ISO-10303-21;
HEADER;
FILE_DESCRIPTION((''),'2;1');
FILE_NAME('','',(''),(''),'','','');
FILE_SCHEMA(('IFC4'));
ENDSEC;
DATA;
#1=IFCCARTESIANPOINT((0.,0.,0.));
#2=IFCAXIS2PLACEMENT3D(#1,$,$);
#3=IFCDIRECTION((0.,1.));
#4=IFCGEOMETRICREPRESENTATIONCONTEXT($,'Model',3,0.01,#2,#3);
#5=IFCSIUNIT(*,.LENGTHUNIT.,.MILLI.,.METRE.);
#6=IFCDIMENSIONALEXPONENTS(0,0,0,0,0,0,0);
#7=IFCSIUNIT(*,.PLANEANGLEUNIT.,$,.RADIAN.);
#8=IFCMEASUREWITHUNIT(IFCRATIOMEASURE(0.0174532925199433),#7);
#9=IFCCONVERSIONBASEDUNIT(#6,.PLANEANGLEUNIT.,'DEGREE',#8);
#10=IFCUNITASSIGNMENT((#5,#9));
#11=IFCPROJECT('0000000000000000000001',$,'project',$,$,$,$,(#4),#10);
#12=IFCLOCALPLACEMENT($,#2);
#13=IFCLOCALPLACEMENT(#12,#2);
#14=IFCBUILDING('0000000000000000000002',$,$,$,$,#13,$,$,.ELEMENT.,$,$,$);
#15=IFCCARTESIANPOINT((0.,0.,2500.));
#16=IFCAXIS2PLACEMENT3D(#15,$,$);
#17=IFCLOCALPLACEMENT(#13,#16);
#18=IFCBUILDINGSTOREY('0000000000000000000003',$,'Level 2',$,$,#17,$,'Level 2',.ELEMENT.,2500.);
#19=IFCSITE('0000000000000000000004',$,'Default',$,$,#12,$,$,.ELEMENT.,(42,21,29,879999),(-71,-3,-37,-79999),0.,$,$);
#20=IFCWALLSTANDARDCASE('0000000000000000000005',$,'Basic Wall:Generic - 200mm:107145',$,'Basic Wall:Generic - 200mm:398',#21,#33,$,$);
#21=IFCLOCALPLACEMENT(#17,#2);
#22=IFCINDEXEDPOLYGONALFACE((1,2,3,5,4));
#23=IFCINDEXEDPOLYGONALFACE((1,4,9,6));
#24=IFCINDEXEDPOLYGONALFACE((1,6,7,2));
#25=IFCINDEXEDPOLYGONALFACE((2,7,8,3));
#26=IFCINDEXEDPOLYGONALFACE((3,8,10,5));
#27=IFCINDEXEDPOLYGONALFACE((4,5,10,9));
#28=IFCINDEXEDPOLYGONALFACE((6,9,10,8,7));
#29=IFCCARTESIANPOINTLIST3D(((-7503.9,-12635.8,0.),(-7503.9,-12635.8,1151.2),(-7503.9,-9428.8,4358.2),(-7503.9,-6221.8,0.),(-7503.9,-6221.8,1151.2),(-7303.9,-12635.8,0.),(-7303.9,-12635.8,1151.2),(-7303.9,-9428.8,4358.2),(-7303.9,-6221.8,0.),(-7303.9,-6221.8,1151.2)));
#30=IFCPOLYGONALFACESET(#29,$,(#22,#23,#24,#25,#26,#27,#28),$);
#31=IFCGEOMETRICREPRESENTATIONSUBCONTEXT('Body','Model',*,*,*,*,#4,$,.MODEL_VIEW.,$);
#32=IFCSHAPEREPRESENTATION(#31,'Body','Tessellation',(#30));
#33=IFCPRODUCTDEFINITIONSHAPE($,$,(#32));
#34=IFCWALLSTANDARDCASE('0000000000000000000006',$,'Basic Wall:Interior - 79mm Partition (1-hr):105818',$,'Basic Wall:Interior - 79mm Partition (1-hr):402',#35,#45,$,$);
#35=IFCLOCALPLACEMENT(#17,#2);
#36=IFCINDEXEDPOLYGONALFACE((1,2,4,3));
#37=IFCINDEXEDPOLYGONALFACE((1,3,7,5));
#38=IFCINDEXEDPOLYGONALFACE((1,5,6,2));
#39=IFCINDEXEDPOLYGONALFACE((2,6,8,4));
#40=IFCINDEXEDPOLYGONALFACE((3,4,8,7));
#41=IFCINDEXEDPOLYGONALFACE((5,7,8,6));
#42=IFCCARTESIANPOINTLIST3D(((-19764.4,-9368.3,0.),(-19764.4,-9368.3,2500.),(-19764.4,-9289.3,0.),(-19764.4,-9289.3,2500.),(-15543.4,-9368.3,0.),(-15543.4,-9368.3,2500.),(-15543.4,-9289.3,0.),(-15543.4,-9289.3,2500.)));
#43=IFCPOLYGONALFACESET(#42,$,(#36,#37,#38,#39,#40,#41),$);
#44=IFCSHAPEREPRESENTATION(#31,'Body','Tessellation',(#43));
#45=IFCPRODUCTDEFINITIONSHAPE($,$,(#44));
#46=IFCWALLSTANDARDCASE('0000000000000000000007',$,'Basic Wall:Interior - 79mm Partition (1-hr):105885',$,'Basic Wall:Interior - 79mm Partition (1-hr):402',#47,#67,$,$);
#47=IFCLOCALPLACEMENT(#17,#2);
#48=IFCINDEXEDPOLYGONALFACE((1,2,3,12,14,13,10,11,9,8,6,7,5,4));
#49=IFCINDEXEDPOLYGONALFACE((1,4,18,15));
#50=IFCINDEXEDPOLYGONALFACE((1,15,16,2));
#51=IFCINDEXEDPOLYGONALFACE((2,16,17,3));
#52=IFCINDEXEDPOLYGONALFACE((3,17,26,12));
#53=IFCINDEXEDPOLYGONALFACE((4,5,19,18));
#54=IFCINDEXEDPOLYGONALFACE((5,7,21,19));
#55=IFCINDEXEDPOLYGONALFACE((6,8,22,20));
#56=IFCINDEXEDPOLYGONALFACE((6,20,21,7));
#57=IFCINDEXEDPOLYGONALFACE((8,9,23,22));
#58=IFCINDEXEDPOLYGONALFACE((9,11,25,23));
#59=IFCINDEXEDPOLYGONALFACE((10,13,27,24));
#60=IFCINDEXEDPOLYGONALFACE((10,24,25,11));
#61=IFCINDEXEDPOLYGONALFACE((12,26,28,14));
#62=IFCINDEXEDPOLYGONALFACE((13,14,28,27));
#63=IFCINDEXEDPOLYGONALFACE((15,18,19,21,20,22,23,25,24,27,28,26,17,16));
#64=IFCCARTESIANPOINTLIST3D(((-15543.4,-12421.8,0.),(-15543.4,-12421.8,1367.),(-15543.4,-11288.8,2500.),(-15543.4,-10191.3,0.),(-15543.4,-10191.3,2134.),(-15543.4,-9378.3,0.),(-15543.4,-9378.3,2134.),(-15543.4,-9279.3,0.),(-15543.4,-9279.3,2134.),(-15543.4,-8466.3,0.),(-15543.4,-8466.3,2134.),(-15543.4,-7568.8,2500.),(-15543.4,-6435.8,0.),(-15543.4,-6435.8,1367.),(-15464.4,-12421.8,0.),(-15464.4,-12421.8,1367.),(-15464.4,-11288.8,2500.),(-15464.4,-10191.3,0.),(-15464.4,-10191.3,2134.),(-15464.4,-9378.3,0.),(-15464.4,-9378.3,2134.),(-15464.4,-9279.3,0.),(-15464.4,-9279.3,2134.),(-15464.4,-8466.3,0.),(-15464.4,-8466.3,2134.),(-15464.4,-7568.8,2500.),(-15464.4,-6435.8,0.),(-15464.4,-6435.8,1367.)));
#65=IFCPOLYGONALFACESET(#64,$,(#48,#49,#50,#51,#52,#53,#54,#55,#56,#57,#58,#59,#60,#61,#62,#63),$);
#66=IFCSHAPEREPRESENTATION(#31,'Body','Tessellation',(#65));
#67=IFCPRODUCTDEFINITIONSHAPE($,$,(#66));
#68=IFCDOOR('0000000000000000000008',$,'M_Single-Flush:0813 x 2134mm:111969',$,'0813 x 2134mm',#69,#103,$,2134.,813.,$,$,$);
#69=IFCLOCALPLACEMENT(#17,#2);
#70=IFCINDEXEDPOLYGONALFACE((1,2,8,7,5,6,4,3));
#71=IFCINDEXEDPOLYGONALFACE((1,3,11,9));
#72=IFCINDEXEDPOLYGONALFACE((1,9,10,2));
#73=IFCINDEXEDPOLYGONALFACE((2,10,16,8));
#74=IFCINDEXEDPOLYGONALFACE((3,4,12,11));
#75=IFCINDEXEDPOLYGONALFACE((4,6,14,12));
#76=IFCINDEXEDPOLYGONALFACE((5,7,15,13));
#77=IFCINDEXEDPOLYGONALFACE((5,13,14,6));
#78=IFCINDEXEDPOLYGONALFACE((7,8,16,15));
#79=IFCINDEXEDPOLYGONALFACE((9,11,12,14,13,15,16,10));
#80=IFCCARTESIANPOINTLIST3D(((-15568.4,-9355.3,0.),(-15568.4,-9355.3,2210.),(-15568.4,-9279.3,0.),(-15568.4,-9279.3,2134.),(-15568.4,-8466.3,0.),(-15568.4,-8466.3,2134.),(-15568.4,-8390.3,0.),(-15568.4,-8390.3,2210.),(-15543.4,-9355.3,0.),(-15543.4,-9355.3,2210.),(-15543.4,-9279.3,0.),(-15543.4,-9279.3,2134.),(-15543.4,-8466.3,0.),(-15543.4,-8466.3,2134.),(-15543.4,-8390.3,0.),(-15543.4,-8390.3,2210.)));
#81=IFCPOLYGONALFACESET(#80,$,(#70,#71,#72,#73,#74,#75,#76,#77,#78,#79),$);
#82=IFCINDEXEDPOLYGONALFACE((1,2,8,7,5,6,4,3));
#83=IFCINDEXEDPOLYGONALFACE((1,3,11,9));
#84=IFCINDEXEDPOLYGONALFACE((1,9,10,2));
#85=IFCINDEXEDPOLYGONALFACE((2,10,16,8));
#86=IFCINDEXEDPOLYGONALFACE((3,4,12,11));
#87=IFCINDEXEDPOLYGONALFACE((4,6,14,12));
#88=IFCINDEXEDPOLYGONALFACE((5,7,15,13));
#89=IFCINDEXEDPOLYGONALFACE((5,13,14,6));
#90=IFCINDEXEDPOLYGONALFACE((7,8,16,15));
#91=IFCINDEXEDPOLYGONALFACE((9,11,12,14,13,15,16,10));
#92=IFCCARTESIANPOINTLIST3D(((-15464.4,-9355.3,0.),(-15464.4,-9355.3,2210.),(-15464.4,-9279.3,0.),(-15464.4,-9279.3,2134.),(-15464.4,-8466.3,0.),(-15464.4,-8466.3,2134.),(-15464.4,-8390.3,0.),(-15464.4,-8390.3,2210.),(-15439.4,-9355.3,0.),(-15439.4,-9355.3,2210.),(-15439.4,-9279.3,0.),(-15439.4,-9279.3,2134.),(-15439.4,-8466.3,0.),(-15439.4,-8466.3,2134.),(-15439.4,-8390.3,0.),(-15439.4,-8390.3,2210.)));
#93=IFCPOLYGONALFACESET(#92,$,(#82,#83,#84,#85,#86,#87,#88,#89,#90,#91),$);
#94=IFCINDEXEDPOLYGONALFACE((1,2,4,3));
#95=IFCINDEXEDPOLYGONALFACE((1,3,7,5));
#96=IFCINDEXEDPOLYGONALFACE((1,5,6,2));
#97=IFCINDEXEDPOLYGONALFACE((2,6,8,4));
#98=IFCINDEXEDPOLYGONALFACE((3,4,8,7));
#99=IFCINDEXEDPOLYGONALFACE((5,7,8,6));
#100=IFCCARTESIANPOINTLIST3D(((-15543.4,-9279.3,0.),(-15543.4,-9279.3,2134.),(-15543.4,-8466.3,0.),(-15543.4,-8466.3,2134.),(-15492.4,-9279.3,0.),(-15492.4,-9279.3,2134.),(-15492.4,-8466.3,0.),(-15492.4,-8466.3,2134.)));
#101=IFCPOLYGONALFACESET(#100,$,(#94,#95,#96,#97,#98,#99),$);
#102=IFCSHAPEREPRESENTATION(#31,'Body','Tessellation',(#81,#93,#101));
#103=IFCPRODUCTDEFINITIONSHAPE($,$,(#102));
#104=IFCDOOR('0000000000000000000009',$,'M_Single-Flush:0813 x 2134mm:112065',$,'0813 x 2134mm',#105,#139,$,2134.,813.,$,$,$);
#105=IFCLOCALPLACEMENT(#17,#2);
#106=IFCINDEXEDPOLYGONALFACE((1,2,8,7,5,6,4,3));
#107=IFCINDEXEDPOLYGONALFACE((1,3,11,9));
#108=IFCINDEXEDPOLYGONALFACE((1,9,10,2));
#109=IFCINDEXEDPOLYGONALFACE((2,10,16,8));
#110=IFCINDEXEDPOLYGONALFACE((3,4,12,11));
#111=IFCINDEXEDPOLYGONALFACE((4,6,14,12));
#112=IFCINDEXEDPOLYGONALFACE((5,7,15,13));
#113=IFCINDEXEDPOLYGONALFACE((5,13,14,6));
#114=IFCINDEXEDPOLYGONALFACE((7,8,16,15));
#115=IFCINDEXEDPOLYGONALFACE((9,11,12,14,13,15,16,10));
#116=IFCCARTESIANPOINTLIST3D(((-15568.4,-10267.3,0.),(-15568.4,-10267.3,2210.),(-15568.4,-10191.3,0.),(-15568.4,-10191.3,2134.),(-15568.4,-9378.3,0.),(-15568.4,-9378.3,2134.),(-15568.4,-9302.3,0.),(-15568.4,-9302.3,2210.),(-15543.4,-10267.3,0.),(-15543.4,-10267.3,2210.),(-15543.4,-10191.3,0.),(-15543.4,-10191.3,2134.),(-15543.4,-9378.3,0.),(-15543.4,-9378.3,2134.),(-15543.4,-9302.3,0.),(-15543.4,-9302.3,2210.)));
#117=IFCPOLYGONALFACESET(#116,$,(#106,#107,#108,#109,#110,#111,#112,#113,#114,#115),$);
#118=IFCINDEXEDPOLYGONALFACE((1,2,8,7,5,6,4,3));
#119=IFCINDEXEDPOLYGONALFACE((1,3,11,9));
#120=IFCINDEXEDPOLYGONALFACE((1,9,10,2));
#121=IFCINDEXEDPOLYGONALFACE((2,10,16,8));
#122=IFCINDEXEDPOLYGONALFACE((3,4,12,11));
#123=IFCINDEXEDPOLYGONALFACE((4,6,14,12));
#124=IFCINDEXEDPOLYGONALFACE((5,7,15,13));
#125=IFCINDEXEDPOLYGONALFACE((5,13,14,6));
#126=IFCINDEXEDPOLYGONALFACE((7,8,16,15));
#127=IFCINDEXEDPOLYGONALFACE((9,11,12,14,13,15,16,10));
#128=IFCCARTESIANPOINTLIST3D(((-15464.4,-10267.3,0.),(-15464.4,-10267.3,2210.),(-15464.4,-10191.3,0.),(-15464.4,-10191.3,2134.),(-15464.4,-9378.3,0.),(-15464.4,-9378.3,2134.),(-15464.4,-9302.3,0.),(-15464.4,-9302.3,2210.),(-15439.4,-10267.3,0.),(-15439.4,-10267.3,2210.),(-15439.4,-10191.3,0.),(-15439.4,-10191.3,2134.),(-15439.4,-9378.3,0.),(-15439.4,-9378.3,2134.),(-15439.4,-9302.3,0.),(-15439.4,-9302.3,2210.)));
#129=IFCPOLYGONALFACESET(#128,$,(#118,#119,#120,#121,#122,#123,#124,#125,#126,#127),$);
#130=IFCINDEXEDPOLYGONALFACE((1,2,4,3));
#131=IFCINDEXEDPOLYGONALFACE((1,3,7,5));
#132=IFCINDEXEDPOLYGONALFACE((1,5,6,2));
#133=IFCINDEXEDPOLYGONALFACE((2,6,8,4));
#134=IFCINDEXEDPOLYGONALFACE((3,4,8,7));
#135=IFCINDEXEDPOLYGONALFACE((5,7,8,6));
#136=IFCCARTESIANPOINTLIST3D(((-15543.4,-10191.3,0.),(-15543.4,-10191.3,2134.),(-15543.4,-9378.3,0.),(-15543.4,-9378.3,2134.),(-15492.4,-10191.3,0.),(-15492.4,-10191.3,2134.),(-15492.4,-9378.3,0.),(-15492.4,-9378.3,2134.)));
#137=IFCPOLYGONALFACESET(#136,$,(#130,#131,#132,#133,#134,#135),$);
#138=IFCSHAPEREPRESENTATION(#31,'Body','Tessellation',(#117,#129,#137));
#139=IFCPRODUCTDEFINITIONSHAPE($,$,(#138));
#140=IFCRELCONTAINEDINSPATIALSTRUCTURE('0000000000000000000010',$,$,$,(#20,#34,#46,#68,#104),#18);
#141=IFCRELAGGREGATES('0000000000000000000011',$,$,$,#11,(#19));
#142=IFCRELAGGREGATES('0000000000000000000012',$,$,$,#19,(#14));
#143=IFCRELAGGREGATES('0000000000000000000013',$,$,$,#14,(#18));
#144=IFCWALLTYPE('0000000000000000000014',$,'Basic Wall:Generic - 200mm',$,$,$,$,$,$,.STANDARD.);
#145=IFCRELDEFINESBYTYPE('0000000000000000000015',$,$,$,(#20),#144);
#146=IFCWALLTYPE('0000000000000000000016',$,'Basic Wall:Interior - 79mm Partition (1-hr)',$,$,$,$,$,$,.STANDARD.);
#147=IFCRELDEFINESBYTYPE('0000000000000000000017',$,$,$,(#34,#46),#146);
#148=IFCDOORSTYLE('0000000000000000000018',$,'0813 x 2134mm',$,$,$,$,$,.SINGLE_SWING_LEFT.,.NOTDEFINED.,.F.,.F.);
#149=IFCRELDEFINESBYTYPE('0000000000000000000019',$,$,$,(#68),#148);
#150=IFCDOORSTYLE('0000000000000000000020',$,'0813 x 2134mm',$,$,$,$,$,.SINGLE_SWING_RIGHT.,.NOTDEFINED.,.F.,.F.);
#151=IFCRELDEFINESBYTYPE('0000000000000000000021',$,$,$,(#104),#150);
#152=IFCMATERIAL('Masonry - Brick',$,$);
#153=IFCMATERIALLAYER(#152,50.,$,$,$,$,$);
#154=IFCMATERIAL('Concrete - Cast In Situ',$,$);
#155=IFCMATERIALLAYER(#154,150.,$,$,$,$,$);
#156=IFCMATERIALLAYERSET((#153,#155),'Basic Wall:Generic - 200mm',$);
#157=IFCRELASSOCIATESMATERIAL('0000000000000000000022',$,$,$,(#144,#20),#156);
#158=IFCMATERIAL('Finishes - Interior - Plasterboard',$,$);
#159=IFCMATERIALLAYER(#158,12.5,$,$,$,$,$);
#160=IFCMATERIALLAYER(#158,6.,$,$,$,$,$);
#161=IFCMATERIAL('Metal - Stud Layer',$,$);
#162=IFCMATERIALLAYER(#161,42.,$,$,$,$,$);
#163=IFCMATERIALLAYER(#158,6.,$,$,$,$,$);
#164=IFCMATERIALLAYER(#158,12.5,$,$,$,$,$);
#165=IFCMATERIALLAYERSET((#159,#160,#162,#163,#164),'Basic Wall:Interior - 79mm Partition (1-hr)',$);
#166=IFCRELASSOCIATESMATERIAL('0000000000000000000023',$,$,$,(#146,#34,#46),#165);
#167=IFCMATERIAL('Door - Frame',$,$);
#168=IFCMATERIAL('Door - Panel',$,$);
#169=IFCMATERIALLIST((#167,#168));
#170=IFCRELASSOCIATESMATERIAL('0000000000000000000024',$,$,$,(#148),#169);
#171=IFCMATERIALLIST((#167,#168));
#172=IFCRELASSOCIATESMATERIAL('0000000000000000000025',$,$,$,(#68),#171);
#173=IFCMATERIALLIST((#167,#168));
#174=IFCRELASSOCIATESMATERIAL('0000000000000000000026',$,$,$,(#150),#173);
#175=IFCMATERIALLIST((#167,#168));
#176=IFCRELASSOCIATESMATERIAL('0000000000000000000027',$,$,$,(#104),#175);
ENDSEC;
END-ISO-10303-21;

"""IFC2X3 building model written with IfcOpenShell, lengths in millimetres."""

from ifc_helpers import new_model, entity, si_unit, converted_unit, direction, frame, frame_2d, origin, origin_2d_with_axis, place, context, subcontext, project, spatial, polyline, rectangle, outline, extrude, clip, halfspace, bounded_halfspace, source, transform, mapped, material, material_list, layer, layer_set, layer_usage, type_object, type_shapes, element, fill, save


model = new_model("IFC2X3")

# Units and contexts
model_context = context("Model", 3, precision=0.01, world=origin(), true_north=direction((0.0, 1.0)))
body_context = subcontext(model_context, "Body", "Model", "MODEL_VIEW")
ifc_project = project(units=[si_unit("LENGTHUNIT", "METRE", prefix="MILLI"), converted_unit("PLANEANGLEUNIT", "DEGREE", entity("IfcRatioMeasure", 0.0174532925199433), si_unit("PLANEANGLEUNIT", "RADIAN"), dimensions=[0, 0, 0, 0, 0, 0, 0])], contexts=[model_context])

# Site, building, storey
site_placement = place(None, origin())
site = spatial("IfcSite", under=ifc_project, at=site_placement, Name="Default", CompositionType="ELEMENT", RefLatitude=(42, 21, 29, 879999), RefLongitude=(-71, -3, -37, -79999), RefElevation=0.0)
building_placement = place(site_placement, origin())
building = spatial("IfcBuilding", under=site, at=building_placement, CompositionType="ELEMENT")
storey_placement = place(building_placement, frame((0.0, 0.0, 2500.0)))
storey = spatial("IfcBuildingStorey", under=building, at=storey_placement, Name="Level 2", LongName="Level 2", CompositionType="ELEMENT", Elevation=2500.0)

# Walls
ifc_material_1 = material(Name="Masonry - Brick")
ifc_layer_1 = layer(ifc_material_1, 50.0)
ifc_material_2 = material(Name="Concrete - Cast In Situ")
ifc_layer_2 = layer(ifc_material_2, 150.0)
ifc_layer_set_1 = layer_set([ifc_layer_1, ifc_layer_2], Name="Basic Wall:Generic - 200mm")
ifc_layer_usage_1 = layer_usage(ifc_layer_set_1, "AXIS2", "NEGATIVE", 100.0)
wall_type_1 = type_object("IfcWallType", Name="Basic Wall:Generic - 200mm", PredefinedType="STANDARD", material=ifc_layer_set_1)
wall_1_placement = place(storey_placement, frame((-7403.9, -6221.8, 0.0), z_axis=(0.0, 0.0, 1.0), x_axis=(0.0, -1.0, 0.0)))
element("IfcWallStandardCase", 1, at=wall_1_placement, inside=storey, type_object=wall_type_1, material=ifc_layer_usage_1, Name="Basic Wall:Generic - 200mm:107145", ObjectType="Basic Wall:Generic - 200mm:398", context=body_context, shape_type="Clipping", body=[
    clip(clip(extrude(rectangle(XDim=6414.0, YDim=200.0, at=frame_2d((3207.0, 0.0), x_axis=(-1.0, 0.0))), origin(), (0.0, 0.0, 1.0), 4358.2), bounded_halfspace(frame((3207.0, -100.0, 4358.2), z_axis=(-0.707107, 0.0, -0.707107), x_axis=(0.0, -1.0, 0.0)), True, frame((3207.0, -100.0, 4358.2)), polyline([(0.0, 0.0), (2993.0, 0.0), (3207.0, 0.0), (3207.0, 200.0), (0.0, 200.0), (0.0, 0.0)]))), bounded_halfspace(frame((0.0, -100.0, 1151.2), z_axis=(0.707107, 0.0, -0.707107), x_axis=(0.0, -1.0, 0.0)), True, frame((0.0, -100.0, 1151.2)), polyline([(0.0, 0.0), (214.0, 0.0), (3207.0, 0.0), (3207.0, 200.0), (0.0, 200.0), (0.0, 0.0)]))),
])
ifc_material_3 = material(Name="Finishes - Interior - Plasterboard")
ifc_layer_3 = layer(ifc_material_3, 12.5)
ifc_layer_4 = layer(ifc_material_3, 6.0)
ifc_material_4 = material(Name="Metal - Stud Layer")
ifc_layer_5 = layer(ifc_material_4, 42.0)
ifc_layer_6 = layer(ifc_material_3, 6.0)
ifc_layer_7 = layer(ifc_material_3, 12.5)
ifc_layer_set_2 = layer_set([ifc_layer_3, ifc_layer_4, ifc_layer_5, ifc_layer_6, ifc_layer_7], Name="Basic Wall:Interior - 79mm Partition (1-hr)")
ifc_layer_usage_2 = layer_usage(ifc_layer_set_2, "AXIS2", "NEGATIVE", 39.5)
wall_type_2 = type_object("IfcWallType", Name="Basic Wall:Interior - 79mm Partition (1-hr)", PredefinedType="STANDARD", material=ifc_layer_set_2)
wall_2_placement = place(storey_placement, frame((-19764.4, -9328.8, 0.0)))
element("IfcWallStandardCase", 2, at=wall_2_placement, inside=storey, type_object=wall_type_2, material=ifc_layer_usage_2, Name="Basic Wall:Interior - 79mm Partition (1-hr):105818", ObjectType="Basic Wall:Interior - 79mm Partition (1-hr):402", context=body_context, shape_type="SweptSolid", body=[
    extrude(rectangle(XDim=4221.0, YDim=79.0, at=frame_2d((2110.5, 0.0), x_axis=(-1.0, 0.0))), origin(), (0.0, 0.0, 1.0), 2500.0),
])

# Wall, openings, doors
ifc_layer_usage_3 = layer_usage(ifc_layer_set_2, "AXIS2", "NEGATIVE", 39.5)
wall_3_placement = place(storey_placement, frame((-15503.9, -12421.8, 0.0), z_axis=(0.0, 0.0, 1.0), x_axis=(0.0, 1.0, 0.0)))
wall_3 = element("IfcWallStandardCase", 3, at=wall_3_placement, inside=storey, type_object=wall_type_2, material=ifc_layer_usage_3, Name="Basic Wall:Interior - 79mm Partition (1-hr):105885", ObjectType="Basic Wall:Interior - 79mm Partition (1-hr):402", context=body_context, shape_type="Clipping", body=[
    clip(clip(extrude(rectangle(XDim=5986.0, YDim=79.0, at=frame_2d((2993.0, 0.0), x_axis=(-1.0, 0.0))), origin(), (0.0, 0.0, 1.0), 2500.0), halfspace(frame((0.0, -39.5, 1367.0), z_axis=(-0.707107, 0.0, 0.707107), x_axis=(0.0, 1.0, 0.0)), False)), halfspace(frame((4853.0, -39.5, 2500.0), z_axis=(0.707107, 0.0, 0.707107), x_axis=(0.0, 1.0, 0.0)), False)),
])
opening_1_placement = place(wall_3_placement, frame((3142.5, -39.5, 0.0)))
opening_1 = element("IfcOpeningElement", 4, at=opening_1_placement, cuts=wall_3, ObjectType="Opening", context=body_context, shape_type="SweptSolid", body=[
    extrude(rectangle(XDim=813.0, YDim=2134.0, at=frame_2d((1067.0, 406.5), x_axis=(0.0, -1.0))), frame((0.0, 0.0, 0.0), z_axis=(0.0, 1.0, 0.0), x_axis=(0.0, 0.0, 1.0)), (0.0, 0.0, 1.0), 79.0),
])
opening_2_placement = place(wall_3_placement, frame((2230.5, -39.5, 0.0)))
opening_2 = element("IfcOpeningElement", 5, at=opening_2_placement, cuts=wall_3, ObjectType="Opening", context=body_context, shape_type="SweptSolid", body=[
    extrude(rectangle(XDim=813.0, YDim=2134.0, at=frame_2d((1067.0, 406.5), x_axis=(0.0, 1.0))), frame((0.0, 0.0, 0.0), z_axis=(0.0, 1.0, 0.0), x_axis=(0.0, 0.0, 1.0)), (0.0, 0.0, 1.0), 79.0),
])
ifc_material_5 = material(Name="Door - Frame")
ifc_material_6 = material(Name="Door - Panel")
ifc_material_list_1 = material_list([ifc_material_5, ifc_material_6])
ifc_material_list_2 = material_list([ifc_material_5, ifc_material_6])
door_style_1 = type_object("IfcDoorStyle", Name="0813 x 2134mm", ConstructionType="NOTDEFINED", OperationType="SINGLE_SWING_LEFT", ParameterTakesPrecedence=False, Sizeable=False, material=ifc_material_list_2)
shared_shape_1 = source(origin(), body_context, "Body", "SweptSolid", [
    extrude(outline(polyline([(-482.5, -1124.0), (482.5, -1124.0), (482.5, 1086.0), (406.5, 1086.0), (406.5, -1048.0), (-406.5, -1048.0), (-406.5, 1086.0), (-482.5, 1086.0), (-482.5, -1124.0)])), frame((406.5, 104.0, 1086.0), z_axis=(0.0, -1.0, 0.0), x_axis=(-1.0, 0.0, 0.0)), (0.0, 0.0, 1.0), 25.0),
    extrude(outline(polyline([(-1124.0, -482.5), (1086.0, -482.5), (1086.0, -406.5), (-1048.0, -406.5), (-1048.0, 406.5), (1086.0, 406.5), (1086.0, 482.5), (-1124.0, 482.5), (-1124.0, -482.5)])), frame((406.5, 0.0, 1086.0), z_axis=(0.0, -1.0, 0.0), x_axis=(0.0, 0.0, -1.0)), (0.0, 0.0, 1.0), 25.0),
    extrude(rectangle(XDim=813.0, YDim=51.0, at=origin_2d_with_axis()), frame((406.5, 53.5, 0.0)), (0.0, 0.0, 1.0), 2134.0),
])
type_shapes(door_style_1, [shared_shape_1])
door_1_placement = place(opening_1_placement, origin())
door_1 = element("IfcDoor", 6, at=door_1_placement, inside=storey, type_object=door_style_1, material=ifc_material_list_1, Name="M_Single-Flush:0813 x 2134mm:111969", ObjectType="0813 x 2134mm", OverallHeight=2134.0, OverallWidth=813.0, context=body_context, shape_type="MappedRepresentation", body=[
    mapped(shared_shape_1, transform((0.0, 0.0, 0.0), scale=1.0)),
])
fill(opening_1, door_1)
ifc_material_list_3 = material_list([ifc_material_5, ifc_material_6])
ifc_material_list_4 = material_list([ifc_material_5, ifc_material_6])
door_style_2 = type_object("IfcDoorStyle", Name="0813 x 2134mm", ConstructionType="NOTDEFINED", OperationType="SINGLE_SWING_RIGHT", ParameterTakesPrecedence=False, Sizeable=False, material=ifc_material_list_4)
shared_shape_2 = source(origin(), body_context, "Body", "SweptSolid", [
    extrude(outline(polyline([(-482.5, -1124.0), (482.5, -1124.0), (482.5, 1086.0), (406.5, 1086.0), (406.5, -1048.0), (-406.5, -1048.0), (-406.5, 1086.0), (-482.5, 1086.0), (-482.5, -1124.0)])), frame((406.5, 79.0, 1086.0), z_axis=(0.0, 1.0, 0.0), x_axis=(1.0, 0.0, 0.0)), (0.0, 0.0, 1.0), 25.0),
    extrude(outline(polyline([(-1124.0, -482.5), (1086.0, -482.5), (1086.0, -406.5), (-1048.0, -406.5), (-1048.0, 406.5), (1086.0, 406.5), (1086.0, 482.5), (-1124.0, 482.5), (-1124.0, -482.5)])), frame((406.5, -25.0, 1086.0), z_axis=(0.0, 1.0, 0.0), x_axis=(0.0, 0.0, -1.0)), (0.0, 0.0, 1.0), 25.0),
    extrude(rectangle(XDim=51.0, YDim=813.0, at=origin_2d_with_axis()), frame((406.5, 53.5, 0.0), z_axis=(0.0, 0.0, 1.0), x_axis=(0.0, 1.0, 0.0)), (0.0, 0.0, 1.0), 2134.0),
])
type_shapes(door_style_2, [shared_shape_2])
door_2_placement = place(opening_2_placement, origin())
door_2 = element("IfcDoor", 7, at=door_2_placement, inside=storey, type_object=door_style_2, material=ifc_material_list_3, Name="M_Single-Flush:0813 x 2134mm:112065", ObjectType="0813 x 2134mm", OverallHeight=2134.0, OverallWidth=813.0, context=body_context, shape_type="MappedRepresentation", body=[
    mapped(shared_shape_2, transform((0.0, 0.0, 0.0), scale=1.0)),
])
fill(opening_2, door_2)

save(model, "model.ifc")
